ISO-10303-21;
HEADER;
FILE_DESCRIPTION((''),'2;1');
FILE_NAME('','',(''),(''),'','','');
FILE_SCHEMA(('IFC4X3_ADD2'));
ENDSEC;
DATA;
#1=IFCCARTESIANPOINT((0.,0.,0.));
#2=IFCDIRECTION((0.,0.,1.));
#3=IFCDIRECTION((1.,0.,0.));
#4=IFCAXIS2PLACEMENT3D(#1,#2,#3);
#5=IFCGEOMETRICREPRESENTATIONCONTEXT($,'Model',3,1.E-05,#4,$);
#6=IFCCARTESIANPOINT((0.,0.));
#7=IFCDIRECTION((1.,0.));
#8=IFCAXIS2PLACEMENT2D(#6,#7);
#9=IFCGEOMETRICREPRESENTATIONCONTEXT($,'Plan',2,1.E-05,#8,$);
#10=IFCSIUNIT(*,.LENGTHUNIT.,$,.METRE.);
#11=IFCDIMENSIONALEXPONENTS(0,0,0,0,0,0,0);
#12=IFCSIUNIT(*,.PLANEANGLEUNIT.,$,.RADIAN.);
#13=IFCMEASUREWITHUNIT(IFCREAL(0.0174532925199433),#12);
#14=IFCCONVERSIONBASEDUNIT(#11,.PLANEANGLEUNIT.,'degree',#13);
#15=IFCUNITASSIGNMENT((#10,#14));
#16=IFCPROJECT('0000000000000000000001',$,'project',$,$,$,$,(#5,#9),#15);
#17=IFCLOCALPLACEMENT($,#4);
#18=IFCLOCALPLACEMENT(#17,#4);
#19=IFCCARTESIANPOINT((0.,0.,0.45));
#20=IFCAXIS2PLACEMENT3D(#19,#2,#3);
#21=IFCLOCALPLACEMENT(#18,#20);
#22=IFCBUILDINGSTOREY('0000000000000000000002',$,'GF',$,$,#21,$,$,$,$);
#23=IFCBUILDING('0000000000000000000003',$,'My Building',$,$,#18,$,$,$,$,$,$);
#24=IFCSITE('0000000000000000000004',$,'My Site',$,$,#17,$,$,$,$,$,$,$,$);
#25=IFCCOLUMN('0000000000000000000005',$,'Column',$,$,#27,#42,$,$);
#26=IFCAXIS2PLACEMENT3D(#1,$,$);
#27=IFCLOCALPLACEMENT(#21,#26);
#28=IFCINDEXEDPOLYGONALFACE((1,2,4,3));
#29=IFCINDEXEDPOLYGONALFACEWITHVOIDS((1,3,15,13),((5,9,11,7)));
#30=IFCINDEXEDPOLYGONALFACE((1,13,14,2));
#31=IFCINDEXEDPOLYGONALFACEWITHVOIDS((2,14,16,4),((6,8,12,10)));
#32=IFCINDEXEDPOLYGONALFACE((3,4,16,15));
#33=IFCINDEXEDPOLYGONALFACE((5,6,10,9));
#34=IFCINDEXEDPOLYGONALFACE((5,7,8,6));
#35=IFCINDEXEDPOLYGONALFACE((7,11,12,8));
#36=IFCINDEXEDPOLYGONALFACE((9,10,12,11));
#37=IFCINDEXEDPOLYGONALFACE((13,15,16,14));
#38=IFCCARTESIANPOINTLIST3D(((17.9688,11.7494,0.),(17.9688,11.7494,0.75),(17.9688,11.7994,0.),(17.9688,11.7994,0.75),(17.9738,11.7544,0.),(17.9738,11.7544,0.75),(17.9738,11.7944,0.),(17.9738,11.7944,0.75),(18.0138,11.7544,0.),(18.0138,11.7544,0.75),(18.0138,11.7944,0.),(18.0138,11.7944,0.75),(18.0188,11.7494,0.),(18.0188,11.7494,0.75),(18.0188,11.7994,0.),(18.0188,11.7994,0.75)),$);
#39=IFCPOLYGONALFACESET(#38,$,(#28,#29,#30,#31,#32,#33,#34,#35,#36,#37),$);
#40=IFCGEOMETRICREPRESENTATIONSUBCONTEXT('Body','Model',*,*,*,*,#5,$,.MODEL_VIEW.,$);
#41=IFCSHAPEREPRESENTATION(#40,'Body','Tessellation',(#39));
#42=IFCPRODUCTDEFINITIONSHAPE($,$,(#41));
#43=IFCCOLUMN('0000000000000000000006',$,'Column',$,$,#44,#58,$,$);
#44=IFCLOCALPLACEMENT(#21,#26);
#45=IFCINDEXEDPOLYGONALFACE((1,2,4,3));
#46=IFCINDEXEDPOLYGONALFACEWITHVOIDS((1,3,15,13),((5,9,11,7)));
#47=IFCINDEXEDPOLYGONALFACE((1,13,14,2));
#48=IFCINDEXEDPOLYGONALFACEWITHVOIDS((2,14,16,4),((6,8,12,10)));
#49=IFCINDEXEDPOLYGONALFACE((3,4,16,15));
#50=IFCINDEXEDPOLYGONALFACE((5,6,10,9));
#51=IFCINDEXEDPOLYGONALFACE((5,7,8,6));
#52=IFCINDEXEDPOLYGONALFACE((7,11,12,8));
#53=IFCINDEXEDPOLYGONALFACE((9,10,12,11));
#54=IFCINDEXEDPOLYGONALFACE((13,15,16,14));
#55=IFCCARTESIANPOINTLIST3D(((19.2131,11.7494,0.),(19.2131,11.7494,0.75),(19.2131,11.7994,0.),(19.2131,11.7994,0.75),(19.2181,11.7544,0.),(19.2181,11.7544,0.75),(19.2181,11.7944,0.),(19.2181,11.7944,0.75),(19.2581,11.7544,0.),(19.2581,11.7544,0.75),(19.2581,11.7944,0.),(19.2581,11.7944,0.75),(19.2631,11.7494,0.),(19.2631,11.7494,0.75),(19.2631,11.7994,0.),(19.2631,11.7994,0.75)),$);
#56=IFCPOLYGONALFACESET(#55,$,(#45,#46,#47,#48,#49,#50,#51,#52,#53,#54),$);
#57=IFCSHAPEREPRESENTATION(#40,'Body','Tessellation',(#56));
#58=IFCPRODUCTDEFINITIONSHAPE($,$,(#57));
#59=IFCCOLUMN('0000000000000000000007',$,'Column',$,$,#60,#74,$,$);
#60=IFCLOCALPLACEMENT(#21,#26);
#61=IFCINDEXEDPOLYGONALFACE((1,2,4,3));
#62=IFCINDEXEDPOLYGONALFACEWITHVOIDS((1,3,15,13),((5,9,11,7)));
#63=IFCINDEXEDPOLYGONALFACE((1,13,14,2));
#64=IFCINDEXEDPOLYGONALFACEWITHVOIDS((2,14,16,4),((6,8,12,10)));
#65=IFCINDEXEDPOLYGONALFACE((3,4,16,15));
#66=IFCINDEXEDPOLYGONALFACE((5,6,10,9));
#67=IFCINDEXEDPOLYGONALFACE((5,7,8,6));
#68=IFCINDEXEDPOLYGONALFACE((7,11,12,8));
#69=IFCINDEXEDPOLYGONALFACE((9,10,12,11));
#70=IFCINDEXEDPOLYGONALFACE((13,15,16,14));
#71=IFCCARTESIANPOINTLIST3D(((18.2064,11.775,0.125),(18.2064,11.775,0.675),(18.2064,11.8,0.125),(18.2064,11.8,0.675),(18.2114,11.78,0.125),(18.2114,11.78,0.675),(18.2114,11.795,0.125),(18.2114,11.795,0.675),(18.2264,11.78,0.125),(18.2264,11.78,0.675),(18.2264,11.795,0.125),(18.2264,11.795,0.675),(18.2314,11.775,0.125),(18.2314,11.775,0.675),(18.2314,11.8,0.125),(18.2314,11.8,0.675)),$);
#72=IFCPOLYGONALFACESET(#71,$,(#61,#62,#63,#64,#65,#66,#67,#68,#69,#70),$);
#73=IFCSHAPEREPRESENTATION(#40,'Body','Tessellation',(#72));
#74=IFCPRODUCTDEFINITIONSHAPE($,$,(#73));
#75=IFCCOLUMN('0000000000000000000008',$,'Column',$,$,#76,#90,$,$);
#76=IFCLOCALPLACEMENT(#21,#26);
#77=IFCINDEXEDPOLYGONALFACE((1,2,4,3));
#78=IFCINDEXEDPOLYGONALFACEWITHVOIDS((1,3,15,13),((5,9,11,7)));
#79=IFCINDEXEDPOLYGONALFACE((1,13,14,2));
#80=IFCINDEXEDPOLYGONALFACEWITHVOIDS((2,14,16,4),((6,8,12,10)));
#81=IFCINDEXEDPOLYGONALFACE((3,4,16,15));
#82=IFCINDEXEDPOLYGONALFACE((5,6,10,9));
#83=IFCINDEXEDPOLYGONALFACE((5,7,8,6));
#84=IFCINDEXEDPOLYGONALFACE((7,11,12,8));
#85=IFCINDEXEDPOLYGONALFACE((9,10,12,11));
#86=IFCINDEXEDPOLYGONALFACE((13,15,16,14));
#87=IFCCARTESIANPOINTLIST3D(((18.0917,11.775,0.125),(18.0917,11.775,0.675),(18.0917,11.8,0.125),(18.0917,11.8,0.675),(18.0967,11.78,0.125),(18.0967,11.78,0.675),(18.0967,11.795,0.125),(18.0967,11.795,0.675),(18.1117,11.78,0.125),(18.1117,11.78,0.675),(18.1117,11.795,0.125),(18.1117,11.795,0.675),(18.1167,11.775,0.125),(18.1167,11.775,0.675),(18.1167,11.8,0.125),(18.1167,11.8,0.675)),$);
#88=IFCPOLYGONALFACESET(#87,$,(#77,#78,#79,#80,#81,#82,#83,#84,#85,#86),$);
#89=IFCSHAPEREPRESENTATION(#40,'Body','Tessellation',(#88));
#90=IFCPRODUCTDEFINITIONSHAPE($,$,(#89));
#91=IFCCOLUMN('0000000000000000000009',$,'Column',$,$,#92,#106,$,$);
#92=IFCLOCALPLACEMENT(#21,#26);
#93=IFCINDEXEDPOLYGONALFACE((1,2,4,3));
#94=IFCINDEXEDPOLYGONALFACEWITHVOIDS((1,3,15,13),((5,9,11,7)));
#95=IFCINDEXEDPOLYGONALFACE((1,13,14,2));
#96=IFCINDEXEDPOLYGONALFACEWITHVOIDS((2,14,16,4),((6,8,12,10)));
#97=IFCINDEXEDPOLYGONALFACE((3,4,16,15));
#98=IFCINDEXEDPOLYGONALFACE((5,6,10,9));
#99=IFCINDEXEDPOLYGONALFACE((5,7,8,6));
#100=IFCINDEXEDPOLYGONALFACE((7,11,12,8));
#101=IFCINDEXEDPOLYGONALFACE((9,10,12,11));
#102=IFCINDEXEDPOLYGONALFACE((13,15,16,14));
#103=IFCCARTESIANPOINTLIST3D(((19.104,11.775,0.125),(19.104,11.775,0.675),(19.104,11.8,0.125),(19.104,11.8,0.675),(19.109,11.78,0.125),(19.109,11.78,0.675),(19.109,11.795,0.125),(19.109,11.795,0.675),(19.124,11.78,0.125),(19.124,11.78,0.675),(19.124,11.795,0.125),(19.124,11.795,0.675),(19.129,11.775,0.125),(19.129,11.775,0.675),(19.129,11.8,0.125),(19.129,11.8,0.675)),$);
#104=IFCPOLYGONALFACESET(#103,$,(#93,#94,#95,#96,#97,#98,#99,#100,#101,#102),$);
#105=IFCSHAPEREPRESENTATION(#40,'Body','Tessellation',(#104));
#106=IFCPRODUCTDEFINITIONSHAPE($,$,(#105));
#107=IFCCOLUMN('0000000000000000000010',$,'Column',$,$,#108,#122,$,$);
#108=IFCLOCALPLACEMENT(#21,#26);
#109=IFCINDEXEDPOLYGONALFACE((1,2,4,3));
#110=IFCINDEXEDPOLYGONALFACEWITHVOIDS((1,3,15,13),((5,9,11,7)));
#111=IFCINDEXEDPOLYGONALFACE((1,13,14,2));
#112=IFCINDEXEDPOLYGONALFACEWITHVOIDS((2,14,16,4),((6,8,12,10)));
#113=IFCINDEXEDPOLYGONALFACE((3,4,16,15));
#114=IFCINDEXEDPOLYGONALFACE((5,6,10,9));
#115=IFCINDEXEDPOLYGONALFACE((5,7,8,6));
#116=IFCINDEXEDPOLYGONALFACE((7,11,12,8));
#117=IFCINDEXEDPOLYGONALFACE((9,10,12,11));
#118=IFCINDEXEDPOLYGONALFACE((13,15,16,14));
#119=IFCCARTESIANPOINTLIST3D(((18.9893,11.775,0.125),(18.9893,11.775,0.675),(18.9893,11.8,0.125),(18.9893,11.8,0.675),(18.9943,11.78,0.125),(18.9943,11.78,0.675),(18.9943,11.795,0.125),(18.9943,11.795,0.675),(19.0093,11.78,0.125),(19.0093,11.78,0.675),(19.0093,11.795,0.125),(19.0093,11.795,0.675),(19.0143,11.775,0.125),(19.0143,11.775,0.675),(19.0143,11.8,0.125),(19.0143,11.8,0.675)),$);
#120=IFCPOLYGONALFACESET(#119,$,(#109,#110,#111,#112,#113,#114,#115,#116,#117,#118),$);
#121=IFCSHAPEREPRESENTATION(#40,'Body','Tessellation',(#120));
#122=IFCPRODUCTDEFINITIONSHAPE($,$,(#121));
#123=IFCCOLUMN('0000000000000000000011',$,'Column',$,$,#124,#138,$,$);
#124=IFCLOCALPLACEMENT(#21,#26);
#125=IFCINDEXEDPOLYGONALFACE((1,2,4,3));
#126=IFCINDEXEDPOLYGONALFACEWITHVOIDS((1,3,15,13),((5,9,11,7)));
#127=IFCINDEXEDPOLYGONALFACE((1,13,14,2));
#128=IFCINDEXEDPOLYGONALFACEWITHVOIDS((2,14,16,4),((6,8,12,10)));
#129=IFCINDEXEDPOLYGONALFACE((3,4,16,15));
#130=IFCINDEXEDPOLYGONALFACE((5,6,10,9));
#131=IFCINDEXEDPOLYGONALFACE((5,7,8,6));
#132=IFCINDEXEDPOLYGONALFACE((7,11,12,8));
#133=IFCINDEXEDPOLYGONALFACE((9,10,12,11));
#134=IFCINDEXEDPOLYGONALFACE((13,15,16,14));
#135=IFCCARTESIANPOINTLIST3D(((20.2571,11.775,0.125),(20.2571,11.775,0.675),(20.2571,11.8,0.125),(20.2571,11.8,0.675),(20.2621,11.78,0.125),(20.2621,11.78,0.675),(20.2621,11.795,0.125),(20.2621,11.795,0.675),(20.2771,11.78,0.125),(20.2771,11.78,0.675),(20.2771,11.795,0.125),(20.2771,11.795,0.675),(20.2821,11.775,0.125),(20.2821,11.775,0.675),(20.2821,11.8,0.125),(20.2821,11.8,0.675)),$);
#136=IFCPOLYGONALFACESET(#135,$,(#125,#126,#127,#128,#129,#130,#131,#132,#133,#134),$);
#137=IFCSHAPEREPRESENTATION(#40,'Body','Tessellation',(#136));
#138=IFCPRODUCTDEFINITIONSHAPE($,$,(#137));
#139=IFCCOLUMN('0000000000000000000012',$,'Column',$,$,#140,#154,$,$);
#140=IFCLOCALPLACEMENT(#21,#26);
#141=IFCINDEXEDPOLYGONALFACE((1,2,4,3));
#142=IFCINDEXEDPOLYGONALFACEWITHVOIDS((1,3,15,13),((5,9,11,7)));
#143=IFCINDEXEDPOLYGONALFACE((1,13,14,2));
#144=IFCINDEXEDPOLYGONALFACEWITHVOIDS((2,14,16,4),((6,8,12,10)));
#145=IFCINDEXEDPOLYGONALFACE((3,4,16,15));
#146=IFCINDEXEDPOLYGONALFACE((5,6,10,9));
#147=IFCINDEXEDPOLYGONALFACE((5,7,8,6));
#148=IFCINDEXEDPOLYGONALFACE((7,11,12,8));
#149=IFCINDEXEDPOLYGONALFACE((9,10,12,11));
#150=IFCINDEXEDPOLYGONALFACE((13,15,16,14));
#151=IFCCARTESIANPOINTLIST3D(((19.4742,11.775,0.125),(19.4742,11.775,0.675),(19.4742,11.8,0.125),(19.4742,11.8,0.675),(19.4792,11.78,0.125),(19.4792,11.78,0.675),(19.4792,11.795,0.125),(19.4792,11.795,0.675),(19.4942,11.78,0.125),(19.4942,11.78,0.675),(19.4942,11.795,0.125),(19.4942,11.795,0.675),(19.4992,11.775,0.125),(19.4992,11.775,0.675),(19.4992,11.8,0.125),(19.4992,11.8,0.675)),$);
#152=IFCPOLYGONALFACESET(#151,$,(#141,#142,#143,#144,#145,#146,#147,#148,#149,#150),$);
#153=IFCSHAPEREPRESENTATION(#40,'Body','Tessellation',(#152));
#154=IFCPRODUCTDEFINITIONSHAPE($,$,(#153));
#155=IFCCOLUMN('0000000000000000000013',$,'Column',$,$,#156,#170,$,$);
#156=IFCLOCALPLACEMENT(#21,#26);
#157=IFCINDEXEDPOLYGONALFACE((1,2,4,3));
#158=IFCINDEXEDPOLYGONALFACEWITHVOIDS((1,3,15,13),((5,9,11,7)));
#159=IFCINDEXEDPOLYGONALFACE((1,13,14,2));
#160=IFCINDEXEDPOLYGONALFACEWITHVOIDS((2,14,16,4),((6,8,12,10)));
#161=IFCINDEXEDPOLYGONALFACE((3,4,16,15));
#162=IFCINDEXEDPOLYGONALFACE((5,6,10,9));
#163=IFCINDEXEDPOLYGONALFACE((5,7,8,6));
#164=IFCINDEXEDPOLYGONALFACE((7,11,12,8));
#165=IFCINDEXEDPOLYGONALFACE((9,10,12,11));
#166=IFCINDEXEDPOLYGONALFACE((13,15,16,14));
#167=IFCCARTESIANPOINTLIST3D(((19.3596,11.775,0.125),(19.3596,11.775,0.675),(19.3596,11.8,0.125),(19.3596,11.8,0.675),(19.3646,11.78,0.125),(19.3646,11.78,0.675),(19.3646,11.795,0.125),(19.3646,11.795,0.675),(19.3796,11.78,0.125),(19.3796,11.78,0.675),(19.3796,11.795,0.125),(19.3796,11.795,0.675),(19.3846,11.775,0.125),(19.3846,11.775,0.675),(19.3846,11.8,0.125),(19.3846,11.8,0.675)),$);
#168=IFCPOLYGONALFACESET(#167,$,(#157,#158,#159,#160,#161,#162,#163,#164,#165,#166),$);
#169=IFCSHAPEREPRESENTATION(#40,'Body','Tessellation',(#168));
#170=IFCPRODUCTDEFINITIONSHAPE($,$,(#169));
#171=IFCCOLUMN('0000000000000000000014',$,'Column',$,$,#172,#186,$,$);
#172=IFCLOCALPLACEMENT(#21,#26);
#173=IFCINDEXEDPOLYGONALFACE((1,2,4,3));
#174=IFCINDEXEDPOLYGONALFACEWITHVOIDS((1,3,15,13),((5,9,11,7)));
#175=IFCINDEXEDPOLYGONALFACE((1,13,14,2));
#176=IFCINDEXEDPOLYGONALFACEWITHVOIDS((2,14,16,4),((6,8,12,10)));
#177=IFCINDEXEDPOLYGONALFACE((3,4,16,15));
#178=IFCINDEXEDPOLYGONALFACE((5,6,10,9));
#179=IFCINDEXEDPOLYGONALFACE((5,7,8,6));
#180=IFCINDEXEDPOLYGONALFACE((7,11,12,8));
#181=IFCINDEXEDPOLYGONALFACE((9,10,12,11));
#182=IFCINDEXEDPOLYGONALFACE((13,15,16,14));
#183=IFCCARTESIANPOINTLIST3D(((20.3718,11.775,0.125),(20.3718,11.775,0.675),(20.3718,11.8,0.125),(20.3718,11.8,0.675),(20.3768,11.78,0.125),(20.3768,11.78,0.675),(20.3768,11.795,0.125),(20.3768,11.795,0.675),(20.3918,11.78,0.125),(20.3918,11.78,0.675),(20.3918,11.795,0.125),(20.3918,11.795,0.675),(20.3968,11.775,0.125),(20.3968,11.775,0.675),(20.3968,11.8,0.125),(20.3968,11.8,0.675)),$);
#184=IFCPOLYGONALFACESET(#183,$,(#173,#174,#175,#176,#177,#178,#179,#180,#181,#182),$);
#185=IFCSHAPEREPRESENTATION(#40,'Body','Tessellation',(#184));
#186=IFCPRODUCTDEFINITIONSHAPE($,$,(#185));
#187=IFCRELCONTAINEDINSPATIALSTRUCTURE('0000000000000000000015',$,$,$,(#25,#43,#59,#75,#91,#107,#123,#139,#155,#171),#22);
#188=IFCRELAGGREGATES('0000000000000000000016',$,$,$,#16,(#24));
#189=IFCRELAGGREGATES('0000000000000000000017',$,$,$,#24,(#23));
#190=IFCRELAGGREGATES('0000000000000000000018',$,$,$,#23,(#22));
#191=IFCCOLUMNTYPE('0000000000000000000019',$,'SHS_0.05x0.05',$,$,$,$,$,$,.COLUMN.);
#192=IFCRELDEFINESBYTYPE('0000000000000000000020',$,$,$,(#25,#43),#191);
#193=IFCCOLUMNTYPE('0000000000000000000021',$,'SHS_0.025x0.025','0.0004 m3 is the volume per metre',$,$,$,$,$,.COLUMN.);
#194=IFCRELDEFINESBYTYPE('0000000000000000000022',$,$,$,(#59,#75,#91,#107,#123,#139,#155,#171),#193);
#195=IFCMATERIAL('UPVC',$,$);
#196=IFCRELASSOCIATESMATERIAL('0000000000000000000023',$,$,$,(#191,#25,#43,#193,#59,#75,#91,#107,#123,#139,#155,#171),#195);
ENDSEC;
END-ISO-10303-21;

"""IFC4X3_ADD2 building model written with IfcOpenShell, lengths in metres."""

from ifc_helpers import new_model, entity, si_unit, converted_unit, frame, origin_with_axes, origin_2d_with_axis, place, context, subcontext, project, spatial, hollow_rectangle, extrude, material, material_profile, profile_set, profile_usage, type_object, element, save


model = new_model("IFC4X3_ADD2")

# Units and contexts
model_context = context("Model", 3, precision=1e-05, world=origin_with_axes())
plan_context = context("Plan", 2, precision=1e-05, world=origin_2d_with_axis())
body_context = subcontext(model_context, "Body", "Model", "MODEL_VIEW")
ifc_project = project(units=[si_unit("LENGTHUNIT", "METRE"), converted_unit("PLANEANGLEUNIT", "degree", entity("IfcReal", 0.0174532925199433), si_unit("PLANEANGLEUNIT", "RADIAN"), dimensions=[0, 0, 0, 0, 0, 0, 0])], contexts=[model_context, plan_context])

# Site, building, storey
site_placement = place(None, origin_with_axes())
site = spatial("IfcSite", under=ifc_project, at=site_placement, Name="My Site")
building_placement = place(site_placement, origin_with_axes())
building = spatial("IfcBuilding", under=site, at=building_placement, Name="My Building")
storey_placement = place(building_placement, frame((0.0, 0.0, 0.45), z_axis=(0.0, 0.0, 1.0), x_axis=(1.0, 0.0, 0.0)))
storey = spatial("IfcBuildingStorey", under=building, at=storey_placement, Name="GF")

# Columns
ifc_material = material(Name="UPVC")
ifc_material_profile_1 = material_profile(ifc_material, hollow_rectangle(XDim=0.05, YDim=0.05, WallThickness=0.005))
ifc_profile_set_1 = profile_set([ifc_material_profile_1])
ifc_profile_usage_1 = profile_usage(ifc_profile_set_1)
column_type_1 = type_object("IfcColumnType", Name="SHS_0.05x0.05", PredefinedType="COLUMN", material=ifc_profile_set_1)
column_1_placement = place(storey_placement, frame((17.9938, 11.7744, 0.0), z_axis=(0.0, 0.0, 1.0), x_axis=(1.0, 0.0, 0.0)))
element("IfcColumn", 1, at=column_1_placement, inside=storey, type_object=column_type_1, material=ifc_profile_usage_1, Name="Column", context=body_context, shape_type="SweptSolid", body=[
    extrude(hollow_rectangle(XDim=0.05, YDim=0.05, WallThickness=0.005), origin_with_axes(), (0.0, 0.0, 1.0), 0.75),
])
ifc_profile_usage_2 = profile_usage(ifc_profile_set_1)
column_2_placement = place(storey_placement, frame((19.2381, 11.7744, 0.0), z_axis=(0.0, 0.0, 1.0), x_axis=(1.0, 0.0, 0.0)))
element("IfcColumn", 2, at=column_2_placement, inside=storey, type_object=column_type_1, material=ifc_profile_usage_2, Name="Column", context=body_context, shape_type="SweptSolid", body=[
    extrude(hollow_rectangle(XDim=0.05, YDim=0.05, WallThickness=0.005), origin_with_axes(), (0.0, 0.0, 1.0), 0.75),
])
ifc_material_profile_2 = material_profile(ifc_material, hollow_rectangle(XDim=0.025, YDim=0.025, WallThickness=0.005))
ifc_profile_set_2 = profile_set([ifc_material_profile_2])
ifc_profile_usage_3 = profile_usage(ifc_profile_set_2, cardinal=5)
column_type_2 = type_object("IfcColumnType", Name="SHS_0.025x0.025", Description="0.0004 m3 is the volume per metre", PredefinedType="COLUMN", material=ifc_profile_set_2)
column_3_placement = place(storey_placement, frame((18.2189, 11.7875, 0.125), z_axis=(0.0, 0.0, 1.0), x_axis=(1.0, 0.0, 0.0)))
element("IfcColumn", 3, at=column_3_placement, inside=storey, type_object=column_type_2, material=ifc_profile_usage_3, Name="Column", context=body_context, shape_type="SweptSolid", body=[
    extrude(hollow_rectangle(XDim=0.025, YDim=0.025, WallThickness=0.005), origin_with_axes(), (0.0, 0.0, 1.0), 0.55),
])
ifc_profile_usage_4 = profile_usage(ifc_profile_set_2, cardinal=5)
column_4_placement = place(storey_placement, frame((18.1042, 11.7875, 0.125), z_axis=(0.0, 0.0, 1.0), x_axis=(1.0, 0.0, 0.0)))
element("IfcColumn", 4, at=column_4_placement, inside=storey, type_object=column_type_2, material=ifc_profile_usage_4, Name="Column", context=body_context, shape_type="SweptSolid", body=[
    extrude(hollow_rectangle(XDim=0.025, YDim=0.025, WallThickness=0.005), origin_with_axes(), (0.0, 0.0, 1.0), 0.55),
])
ifc_profile_usage_5 = profile_usage(ifc_profile_set_2, cardinal=5)
column_5_placement = place(storey_placement, frame((19.1165, 11.7875, 0.125), z_axis=(0.0, 0.0, 1.0), x_axis=(1.0, 0.0, 0.0)))
element("IfcColumn", 5, at=column_5_placement, inside=storey, type_object=column_type_2, material=ifc_profile_usage_5, Name="Column", context=body_context, shape_type="SweptSolid", body=[
    extrude(hollow_rectangle(XDim=0.025, YDim=0.025, WallThickness=0.005), origin_with_axes(), (0.0, 0.0, 1.0), 0.55),
])
ifc_profile_usage_6 = profile_usage(ifc_profile_set_2, cardinal=5)
column_6_placement = place(storey_placement, frame((19.0018, 11.7875, 0.125), z_axis=(0.0, 0.0, 1.0), x_axis=(1.0, 0.0, 0.0)))
element("IfcColumn", 6, at=column_6_placement, inside=storey, type_object=column_type_2, material=ifc_profile_usage_6, Name="Column", context=body_context, shape_type="SweptSolid", body=[
    extrude(hollow_rectangle(XDim=0.025, YDim=0.025, WallThickness=0.005), origin_with_axes(), (0.0, 0.0, 1.0), 0.55),
])
ifc_profile_usage_7 = profile_usage(ifc_profile_set_2, cardinal=5)
column_7_placement = place(storey_placement, frame((20.2696, 11.7875, 0.125), z_axis=(0.0, 0.0, 1.0), x_axis=(1.0, 0.0, 0.0)))
element("IfcColumn", 7, at=column_7_placement, inside=storey, type_object=column_type_2, material=ifc_profile_usage_7, Name="Column", context=body_context, shape_type="SweptSolid", body=[
    extrude(hollow_rectangle(XDim=0.025, YDim=0.025, WallThickness=0.005), origin_with_axes(), (0.0, 0.0, 1.0), 0.55),
])
ifc_profile_usage_8 = profile_usage(ifc_profile_set_2, cardinal=5)
column_8_placement = place(storey_placement, frame((19.4867, 11.7875, 0.125), z_axis=(0.0, 0.0, 1.0), x_axis=(1.0, 0.0, 0.0)))
element("IfcColumn", 8, at=column_8_placement, inside=storey, type_object=column_type_2, material=ifc_profile_usage_8, Name="Column", context=body_context, shape_type="SweptSolid", body=[
    extrude(hollow_rectangle(XDim=0.025, YDim=0.025, WallThickness=0.005), origin_with_axes(), (0.0, 0.0, 1.0), 0.55),
])
ifc_profile_usage_9 = profile_usage(ifc_profile_set_2, cardinal=5)
column_9_placement = place(storey_placement, frame((19.3721, 11.7875, 0.125), z_axis=(0.0, 0.0, 1.0), x_axis=(1.0, 0.0, 0.0)))
element("IfcColumn", 9, at=column_9_placement, inside=storey, type_object=column_type_2, material=ifc_profile_usage_9, Name="Column", context=body_context, shape_type="SweptSolid", body=[
    extrude(hollow_rectangle(XDim=0.025, YDim=0.025, WallThickness=0.005), origin_with_axes(), (0.0, 0.0, 1.0), 0.55),
])
ifc_profile_usage_10 = profile_usage(ifc_profile_set_2, cardinal=5)
column_10_placement = place(storey_placement, frame((20.3843, 11.7875, 0.125), z_axis=(0.0, 0.0, 1.0), x_axis=(1.0, 0.0, 0.0)))
element("IfcColumn", 10, at=column_10_placement, inside=storey, type_object=column_type_2, material=ifc_profile_usage_10, Name="Column", context=body_context, shape_type="SweptSolid", body=[
    extrude(hollow_rectangle(XDim=0.025, YDim=0.025, WallThickness=0.005), origin_with_axes(), (0.0, 0.0, 1.0), 0.55),
])

save(model, "model.ifc")
